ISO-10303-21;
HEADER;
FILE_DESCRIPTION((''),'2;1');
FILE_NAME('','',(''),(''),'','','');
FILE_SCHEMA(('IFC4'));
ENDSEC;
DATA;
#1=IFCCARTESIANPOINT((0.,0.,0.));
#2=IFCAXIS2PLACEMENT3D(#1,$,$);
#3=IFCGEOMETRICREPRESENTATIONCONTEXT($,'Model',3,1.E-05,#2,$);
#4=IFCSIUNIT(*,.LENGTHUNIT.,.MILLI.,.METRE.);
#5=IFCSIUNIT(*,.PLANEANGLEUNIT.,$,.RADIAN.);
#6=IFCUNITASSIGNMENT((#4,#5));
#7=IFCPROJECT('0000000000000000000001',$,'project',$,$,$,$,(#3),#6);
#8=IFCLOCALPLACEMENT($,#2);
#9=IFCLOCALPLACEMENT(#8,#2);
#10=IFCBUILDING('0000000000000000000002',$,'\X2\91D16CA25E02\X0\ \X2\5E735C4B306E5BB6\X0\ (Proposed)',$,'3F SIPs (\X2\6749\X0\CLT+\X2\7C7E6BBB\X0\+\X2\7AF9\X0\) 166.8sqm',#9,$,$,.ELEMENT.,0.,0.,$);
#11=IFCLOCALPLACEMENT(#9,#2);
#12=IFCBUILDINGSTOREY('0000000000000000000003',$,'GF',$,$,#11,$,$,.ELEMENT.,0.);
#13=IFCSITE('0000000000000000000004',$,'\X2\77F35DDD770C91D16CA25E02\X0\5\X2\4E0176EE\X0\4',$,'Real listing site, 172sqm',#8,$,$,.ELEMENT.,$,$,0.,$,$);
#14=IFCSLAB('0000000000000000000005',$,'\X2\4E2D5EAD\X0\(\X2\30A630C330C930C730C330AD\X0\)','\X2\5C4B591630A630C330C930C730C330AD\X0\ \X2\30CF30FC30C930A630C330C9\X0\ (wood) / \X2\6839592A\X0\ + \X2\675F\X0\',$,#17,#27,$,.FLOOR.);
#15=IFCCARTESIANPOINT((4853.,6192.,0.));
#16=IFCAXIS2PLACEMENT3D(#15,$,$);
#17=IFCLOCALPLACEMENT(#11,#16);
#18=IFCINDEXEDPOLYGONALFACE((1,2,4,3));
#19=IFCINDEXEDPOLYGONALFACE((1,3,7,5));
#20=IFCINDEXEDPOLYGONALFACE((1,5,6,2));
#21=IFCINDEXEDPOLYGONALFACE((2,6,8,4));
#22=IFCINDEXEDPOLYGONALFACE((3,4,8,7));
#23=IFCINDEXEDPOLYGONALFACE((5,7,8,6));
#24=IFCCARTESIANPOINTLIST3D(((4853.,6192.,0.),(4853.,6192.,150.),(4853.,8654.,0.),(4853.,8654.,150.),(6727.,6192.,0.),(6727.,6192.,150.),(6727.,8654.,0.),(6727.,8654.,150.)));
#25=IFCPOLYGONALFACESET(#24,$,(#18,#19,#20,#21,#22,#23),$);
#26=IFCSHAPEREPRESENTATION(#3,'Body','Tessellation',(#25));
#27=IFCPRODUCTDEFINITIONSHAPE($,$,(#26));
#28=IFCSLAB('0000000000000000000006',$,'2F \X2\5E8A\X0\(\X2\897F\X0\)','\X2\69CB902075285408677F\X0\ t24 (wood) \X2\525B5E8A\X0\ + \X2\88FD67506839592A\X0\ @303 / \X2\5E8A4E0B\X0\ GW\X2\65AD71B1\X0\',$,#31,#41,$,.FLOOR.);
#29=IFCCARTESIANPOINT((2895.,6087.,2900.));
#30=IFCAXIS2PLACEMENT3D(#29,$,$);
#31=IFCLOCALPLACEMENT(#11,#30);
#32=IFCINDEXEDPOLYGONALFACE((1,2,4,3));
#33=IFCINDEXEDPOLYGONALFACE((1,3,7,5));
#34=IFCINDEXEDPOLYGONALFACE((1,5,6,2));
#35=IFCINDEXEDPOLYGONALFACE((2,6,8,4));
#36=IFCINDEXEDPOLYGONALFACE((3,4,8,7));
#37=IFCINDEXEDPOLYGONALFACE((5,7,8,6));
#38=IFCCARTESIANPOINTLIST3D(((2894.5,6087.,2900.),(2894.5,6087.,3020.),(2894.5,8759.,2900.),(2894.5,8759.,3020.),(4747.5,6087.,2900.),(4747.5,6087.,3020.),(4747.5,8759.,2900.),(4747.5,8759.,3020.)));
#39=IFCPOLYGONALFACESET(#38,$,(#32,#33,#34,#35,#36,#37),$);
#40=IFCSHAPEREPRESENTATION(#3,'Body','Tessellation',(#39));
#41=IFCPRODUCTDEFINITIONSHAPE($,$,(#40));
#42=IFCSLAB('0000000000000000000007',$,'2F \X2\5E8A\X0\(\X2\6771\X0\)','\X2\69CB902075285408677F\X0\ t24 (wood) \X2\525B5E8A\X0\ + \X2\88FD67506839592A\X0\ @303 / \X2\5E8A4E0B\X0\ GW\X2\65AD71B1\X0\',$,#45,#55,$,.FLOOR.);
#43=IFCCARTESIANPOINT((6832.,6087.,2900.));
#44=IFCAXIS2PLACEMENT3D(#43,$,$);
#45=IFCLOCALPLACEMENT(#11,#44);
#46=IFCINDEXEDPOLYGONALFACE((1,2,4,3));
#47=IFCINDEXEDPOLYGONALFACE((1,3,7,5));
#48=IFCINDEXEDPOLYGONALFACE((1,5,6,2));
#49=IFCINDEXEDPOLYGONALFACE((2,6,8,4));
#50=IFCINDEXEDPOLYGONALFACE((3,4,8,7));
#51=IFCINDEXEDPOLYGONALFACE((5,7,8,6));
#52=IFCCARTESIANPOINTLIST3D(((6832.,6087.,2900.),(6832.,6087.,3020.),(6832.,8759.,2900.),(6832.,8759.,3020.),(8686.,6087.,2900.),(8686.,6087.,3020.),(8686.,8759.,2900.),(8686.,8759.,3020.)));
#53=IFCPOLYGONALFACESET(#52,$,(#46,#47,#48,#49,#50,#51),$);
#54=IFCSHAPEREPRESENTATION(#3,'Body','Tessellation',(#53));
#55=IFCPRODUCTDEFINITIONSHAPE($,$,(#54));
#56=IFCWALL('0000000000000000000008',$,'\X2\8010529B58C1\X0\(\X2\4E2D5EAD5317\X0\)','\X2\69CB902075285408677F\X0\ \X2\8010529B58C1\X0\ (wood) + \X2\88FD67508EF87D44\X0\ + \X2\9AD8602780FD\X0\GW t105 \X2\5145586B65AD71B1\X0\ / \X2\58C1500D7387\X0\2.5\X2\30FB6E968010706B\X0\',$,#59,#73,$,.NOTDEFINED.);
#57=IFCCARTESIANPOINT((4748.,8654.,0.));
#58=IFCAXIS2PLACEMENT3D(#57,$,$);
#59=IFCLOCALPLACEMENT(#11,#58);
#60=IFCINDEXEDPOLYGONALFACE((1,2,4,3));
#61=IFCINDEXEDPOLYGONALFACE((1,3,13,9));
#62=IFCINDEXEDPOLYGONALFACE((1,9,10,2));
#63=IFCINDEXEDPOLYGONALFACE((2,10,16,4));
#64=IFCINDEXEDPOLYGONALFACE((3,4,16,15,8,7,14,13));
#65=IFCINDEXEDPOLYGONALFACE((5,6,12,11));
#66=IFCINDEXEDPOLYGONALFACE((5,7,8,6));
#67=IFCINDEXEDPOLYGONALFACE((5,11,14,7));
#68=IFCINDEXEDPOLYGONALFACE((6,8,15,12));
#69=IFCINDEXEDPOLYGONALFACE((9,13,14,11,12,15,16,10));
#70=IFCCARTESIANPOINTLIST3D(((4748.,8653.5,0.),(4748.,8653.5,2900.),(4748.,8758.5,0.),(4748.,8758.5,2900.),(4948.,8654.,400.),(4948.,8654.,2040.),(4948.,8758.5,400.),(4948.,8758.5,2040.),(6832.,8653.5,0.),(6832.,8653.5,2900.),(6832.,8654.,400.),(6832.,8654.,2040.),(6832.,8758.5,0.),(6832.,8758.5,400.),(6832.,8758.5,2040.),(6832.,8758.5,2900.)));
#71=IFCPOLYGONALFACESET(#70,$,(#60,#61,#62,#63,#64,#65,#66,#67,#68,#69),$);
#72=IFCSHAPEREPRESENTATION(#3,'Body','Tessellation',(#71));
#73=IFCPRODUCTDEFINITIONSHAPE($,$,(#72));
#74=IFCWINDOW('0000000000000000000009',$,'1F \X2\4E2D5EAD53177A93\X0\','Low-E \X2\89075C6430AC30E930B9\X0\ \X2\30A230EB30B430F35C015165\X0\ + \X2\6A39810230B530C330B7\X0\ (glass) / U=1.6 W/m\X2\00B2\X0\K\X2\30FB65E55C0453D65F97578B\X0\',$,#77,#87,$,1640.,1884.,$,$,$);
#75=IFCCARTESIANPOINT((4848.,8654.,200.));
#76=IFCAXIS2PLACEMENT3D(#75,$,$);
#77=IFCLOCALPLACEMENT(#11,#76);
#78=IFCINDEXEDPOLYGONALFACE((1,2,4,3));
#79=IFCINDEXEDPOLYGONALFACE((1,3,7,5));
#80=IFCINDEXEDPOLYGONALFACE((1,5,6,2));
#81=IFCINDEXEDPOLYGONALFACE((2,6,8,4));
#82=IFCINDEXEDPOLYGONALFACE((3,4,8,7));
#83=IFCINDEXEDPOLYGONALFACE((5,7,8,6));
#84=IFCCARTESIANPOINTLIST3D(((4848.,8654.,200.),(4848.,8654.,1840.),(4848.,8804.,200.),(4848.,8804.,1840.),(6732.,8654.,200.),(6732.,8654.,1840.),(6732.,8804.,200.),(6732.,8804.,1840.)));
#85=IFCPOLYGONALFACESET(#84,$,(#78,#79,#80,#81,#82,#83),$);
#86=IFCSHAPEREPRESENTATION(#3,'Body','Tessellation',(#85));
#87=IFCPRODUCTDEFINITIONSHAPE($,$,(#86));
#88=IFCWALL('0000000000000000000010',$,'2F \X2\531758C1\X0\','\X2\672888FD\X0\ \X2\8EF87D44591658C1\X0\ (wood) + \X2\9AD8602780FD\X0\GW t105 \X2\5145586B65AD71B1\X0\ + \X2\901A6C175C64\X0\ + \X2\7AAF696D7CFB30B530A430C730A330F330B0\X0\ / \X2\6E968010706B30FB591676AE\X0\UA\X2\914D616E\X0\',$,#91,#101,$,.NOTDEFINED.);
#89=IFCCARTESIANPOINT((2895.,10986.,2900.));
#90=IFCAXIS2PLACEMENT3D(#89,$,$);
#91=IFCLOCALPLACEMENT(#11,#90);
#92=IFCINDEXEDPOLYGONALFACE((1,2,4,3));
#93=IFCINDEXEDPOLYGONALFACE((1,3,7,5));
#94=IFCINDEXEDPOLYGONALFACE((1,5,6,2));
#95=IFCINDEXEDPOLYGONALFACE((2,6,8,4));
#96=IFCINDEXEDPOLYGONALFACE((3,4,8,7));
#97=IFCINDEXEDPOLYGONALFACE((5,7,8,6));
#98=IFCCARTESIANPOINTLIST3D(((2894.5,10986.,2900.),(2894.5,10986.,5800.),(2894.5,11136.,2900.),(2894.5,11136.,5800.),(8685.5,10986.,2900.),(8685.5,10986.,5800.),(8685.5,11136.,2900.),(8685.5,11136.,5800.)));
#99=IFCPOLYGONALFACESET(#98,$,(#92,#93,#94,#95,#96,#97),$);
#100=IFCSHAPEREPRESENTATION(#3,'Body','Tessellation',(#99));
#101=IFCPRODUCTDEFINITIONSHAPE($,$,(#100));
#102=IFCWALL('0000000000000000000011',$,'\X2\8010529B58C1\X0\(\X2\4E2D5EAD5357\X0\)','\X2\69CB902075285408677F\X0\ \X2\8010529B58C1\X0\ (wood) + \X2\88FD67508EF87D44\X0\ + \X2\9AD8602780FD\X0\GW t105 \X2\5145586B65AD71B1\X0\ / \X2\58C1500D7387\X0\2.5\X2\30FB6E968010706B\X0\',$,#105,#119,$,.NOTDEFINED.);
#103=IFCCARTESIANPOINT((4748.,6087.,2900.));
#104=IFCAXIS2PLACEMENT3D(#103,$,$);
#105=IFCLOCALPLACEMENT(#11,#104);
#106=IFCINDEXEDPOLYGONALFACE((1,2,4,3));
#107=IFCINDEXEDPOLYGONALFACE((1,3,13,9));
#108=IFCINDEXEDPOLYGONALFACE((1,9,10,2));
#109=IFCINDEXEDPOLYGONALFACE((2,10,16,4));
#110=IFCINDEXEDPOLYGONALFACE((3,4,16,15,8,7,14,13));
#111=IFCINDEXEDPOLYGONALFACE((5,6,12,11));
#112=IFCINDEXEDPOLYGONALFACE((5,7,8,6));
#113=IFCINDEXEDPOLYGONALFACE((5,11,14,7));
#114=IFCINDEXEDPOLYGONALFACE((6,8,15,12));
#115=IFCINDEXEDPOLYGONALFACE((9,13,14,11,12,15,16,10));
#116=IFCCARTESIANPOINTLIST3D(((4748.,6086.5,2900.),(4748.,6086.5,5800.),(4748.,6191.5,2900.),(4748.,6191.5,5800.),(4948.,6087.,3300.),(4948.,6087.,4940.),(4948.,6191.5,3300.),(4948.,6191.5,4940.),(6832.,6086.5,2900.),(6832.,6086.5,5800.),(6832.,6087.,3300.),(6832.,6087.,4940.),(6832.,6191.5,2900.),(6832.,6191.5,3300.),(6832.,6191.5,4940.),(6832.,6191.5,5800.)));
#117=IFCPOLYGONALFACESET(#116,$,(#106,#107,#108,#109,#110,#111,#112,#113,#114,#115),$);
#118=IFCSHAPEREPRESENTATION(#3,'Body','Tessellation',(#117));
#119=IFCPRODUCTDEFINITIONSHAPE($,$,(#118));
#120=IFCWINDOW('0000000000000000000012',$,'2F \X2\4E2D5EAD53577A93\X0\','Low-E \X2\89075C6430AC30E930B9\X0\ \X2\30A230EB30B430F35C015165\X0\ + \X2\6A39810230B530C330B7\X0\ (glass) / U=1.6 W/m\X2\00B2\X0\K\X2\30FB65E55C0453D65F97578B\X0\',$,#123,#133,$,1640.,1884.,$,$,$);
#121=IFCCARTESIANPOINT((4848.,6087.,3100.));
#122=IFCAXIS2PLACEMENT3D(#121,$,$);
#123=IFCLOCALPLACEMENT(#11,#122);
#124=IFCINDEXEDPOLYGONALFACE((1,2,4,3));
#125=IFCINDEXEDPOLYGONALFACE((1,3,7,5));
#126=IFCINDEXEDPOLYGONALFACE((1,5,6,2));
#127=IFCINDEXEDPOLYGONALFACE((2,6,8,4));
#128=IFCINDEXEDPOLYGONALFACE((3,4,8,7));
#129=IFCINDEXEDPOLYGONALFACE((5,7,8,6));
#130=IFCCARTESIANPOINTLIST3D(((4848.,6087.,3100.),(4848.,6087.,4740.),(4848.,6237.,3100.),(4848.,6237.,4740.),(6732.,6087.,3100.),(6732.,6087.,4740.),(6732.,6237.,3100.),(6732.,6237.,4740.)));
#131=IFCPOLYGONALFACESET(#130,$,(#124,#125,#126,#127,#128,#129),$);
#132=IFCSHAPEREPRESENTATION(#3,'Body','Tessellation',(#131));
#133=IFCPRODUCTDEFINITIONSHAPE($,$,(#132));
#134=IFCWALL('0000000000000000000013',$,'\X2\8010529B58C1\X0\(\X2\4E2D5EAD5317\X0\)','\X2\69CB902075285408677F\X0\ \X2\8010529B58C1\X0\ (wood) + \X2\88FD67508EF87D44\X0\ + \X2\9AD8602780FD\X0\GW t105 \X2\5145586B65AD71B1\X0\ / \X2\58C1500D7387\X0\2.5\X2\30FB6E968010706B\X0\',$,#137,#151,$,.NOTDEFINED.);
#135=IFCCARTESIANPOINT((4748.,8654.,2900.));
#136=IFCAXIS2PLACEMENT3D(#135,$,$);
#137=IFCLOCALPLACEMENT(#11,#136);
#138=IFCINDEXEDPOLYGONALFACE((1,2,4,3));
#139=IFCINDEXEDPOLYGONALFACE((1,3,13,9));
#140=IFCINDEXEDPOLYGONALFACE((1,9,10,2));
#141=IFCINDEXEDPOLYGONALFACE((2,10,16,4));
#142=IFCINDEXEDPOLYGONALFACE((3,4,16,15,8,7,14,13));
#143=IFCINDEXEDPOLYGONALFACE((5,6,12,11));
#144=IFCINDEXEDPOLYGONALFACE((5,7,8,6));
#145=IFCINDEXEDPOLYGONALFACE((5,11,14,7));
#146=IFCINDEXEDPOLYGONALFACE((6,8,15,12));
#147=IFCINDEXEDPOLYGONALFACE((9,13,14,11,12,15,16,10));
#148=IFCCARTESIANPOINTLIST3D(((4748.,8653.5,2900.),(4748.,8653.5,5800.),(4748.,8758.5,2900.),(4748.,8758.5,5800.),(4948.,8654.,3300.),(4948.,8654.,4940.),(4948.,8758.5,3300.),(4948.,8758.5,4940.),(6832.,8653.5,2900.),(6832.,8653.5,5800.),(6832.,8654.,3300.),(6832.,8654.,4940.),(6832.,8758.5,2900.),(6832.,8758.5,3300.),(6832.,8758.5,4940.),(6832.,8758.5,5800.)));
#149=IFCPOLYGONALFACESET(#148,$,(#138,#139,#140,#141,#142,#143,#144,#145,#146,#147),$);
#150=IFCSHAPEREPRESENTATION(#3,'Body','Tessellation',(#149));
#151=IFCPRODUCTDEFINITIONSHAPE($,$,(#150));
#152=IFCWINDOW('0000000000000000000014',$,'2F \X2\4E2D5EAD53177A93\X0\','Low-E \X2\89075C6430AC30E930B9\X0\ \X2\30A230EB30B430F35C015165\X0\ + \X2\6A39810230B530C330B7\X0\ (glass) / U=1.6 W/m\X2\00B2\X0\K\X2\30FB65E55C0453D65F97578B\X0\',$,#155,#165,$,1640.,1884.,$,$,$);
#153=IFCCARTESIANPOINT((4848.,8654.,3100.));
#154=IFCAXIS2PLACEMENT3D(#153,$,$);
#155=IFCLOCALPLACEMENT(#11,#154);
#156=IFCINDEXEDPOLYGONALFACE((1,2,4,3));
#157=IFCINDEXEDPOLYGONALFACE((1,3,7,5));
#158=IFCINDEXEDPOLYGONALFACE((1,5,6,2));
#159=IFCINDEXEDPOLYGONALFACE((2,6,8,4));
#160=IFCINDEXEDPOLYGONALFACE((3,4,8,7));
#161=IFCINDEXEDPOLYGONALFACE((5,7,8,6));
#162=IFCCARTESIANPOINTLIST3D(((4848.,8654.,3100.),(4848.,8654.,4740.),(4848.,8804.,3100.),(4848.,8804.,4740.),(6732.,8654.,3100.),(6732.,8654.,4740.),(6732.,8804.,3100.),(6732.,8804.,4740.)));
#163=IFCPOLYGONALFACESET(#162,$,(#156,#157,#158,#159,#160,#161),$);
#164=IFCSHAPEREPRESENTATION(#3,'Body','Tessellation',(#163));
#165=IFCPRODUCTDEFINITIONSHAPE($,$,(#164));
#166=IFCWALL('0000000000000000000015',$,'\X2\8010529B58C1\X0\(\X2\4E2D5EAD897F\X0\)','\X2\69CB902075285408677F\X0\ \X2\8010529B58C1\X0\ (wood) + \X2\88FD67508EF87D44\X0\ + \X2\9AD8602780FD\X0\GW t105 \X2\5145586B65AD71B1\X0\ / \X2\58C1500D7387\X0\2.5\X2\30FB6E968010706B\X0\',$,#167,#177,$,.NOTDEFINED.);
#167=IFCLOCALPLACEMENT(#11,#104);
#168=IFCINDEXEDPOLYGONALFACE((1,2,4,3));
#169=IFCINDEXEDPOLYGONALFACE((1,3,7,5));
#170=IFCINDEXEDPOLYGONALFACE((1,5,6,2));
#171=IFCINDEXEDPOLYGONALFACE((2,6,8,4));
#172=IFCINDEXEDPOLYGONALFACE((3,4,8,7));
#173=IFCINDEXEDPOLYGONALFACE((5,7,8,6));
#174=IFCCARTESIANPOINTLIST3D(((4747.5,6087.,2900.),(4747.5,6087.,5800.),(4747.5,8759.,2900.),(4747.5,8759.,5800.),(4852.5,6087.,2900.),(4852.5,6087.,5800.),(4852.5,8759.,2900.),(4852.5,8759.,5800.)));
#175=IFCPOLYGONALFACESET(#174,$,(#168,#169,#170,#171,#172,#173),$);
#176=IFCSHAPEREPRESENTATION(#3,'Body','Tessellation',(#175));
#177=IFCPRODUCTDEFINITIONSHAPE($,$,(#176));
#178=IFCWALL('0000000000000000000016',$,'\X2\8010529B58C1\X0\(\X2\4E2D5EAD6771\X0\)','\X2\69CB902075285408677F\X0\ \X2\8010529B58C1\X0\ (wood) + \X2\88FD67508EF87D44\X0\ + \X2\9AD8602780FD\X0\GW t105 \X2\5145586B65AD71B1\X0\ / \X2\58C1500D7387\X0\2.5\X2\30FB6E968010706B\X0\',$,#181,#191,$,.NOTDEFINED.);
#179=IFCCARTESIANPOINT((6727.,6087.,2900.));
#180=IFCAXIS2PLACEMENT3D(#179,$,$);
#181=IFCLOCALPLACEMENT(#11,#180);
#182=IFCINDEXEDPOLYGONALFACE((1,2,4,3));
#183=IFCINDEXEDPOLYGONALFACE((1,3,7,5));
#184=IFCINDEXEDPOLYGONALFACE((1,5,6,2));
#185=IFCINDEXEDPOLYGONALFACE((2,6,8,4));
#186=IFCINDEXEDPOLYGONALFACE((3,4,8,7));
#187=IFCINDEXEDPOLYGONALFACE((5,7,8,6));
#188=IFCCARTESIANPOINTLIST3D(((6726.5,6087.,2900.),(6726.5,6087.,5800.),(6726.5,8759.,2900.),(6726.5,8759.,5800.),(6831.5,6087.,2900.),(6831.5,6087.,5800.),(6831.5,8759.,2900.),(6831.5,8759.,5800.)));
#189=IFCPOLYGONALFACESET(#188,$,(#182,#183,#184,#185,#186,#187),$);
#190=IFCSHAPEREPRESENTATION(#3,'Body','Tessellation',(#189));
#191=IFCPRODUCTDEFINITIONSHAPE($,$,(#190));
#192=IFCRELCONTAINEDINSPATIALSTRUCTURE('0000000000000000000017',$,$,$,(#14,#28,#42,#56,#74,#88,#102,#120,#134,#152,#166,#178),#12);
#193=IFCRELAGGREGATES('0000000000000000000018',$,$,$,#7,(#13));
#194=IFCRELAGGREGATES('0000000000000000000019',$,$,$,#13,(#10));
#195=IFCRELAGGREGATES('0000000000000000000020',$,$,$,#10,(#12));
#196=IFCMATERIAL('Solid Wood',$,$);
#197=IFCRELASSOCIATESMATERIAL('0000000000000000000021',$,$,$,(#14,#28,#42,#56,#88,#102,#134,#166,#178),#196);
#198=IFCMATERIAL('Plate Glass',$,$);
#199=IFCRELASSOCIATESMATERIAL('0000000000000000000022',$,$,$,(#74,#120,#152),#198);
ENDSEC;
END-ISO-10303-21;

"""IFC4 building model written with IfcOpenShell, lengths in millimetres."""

from ifc_helpers import new_model, si_unit, frame, frame_2d, origin, place, context, project, spatial, rectangle, extrude, material, element, fill, save


model = new_model("IFC4")

# Units and contexts
model_context = context("Model", 3, precision=1e-05, world=origin())
ifc_project = project(units=[si_unit("LENGTHUNIT", "METRE", prefix="MILLI"), si_unit("PLANEANGLEUNIT", "RADIAN")], contexts=[model_context])

# Site, building, storey
site_placement = place(None, origin())
site = spatial("IfcSite", under=ifc_project, at=site_placement, Name="石川県金沢市5丁目4", ObjectType="Real listing site, 172sqm", CompositionType="ELEMENT", RefElevation=0.0)
building_placement = place(site_placement, origin())
building = spatial("IfcBuilding", under=site, at=building_placement, Name="金沢市 平屋の家 (Proposed)", ObjectType="3F SIPs (杉CLT+籾殻+竹) 166.8sqm", CompositionType="ELEMENT", ElevationOfRefHeight=0.0, ElevationOfTerrain=0.0)
storey_placement = place(building_placement, origin())
storey = spatial("IfcBuildingStorey", under=building, at=storey_placement, Name="GF", CompositionType="ELEMENT", Elevation=0.0)

# Slabs
ifc_material_1 = material(Name="Solid Wood")
slab_1_placement = place(storey_placement, frame((4853.0, 6192.0, 0.0)))
element("IfcSlab", 1, at=slab_1_placement, inside=storey, material=ifc_material_1, Name="中庭(ウッドデッキ)", Description="屋外ウッドデッキ ハードウッド (wood) / 根太 + 束", PredefinedType="FLOOR", context=model_context, shape_type="SweptSolid", body=[
    extrude(rectangle(XDim=1874.0, YDim=2462.0, at=frame_2d((937.0, 1231.0))), frame((4853.0, 6192.0, 0.0)), (0.0, 0.0, 1.0), 150.0),
])
slab_2_placement = place(storey_placement, frame((2895.0, 6087.0, 2900.0)))
element("IfcSlab", 2, at=slab_2_placement, inside=storey, material=ifc_material_1, Name="2F 床(西)", Description="構造用合板 t24 (wood) 剛床 + 製材根太 @303 / 床下 GW断熱", PredefinedType="FLOOR", context=model_context, shape_type="SweptSolid", body=[
    extrude(rectangle(XDim=1853.0, YDim=2672.0, at=frame_2d((926.0, 1336.0))), frame((2895.0, 6087.0, 2900.0)), (0.0, 0.0, 1.0), 120.0),
])
slab_3_placement = place(storey_placement, frame((6832.0, 6087.0, 2900.0)))
element("IfcSlab", 3, at=slab_3_placement, inside=storey, material=ifc_material_1, Name="2F 床(東)", Description="構造用合板 t24 (wood) 剛床 + 製材根太 @303 / 床下 GW断熱", PredefinedType="FLOOR", context=model_context, shape_type="SweptSolid", body=[
    extrude(rectangle(XDim=1854.0, YDim=2672.0, at=frame_2d((927.0, 1336.0))), frame((6832.0, 6087.0, 2900.0)), (0.0, 0.0, 1.0), 120.0),
])

# Wall, opening, window
wall_1_placement = place(storey_placement, frame((4748.0, 8654.0, 0.0)))
wall_1 = element("IfcWall", 4, at=wall_1_placement, inside=storey, material=ifc_material_1, Name="耐力壁(中庭北)", Description="構造用合板 耐力壁 (wood) + 製材軸組 + 高性能GW t105 充填断熱 / 壁倍率2.5・準耐火", PredefinedType="NOTDEFINED", context=model_context, shape_type="SweptSolid", body=[
    extrude(rectangle(XDim=2084.0, YDim=105.0, at=frame_2d((1042.0, 52.0))), frame((4748.0, 8654.0, 0.0)), (0.0, 0.0, 1.0), 2900.0),
])
opening_1_placement = place(storey_placement, frame((4848.0, 8654.0, 200.0)))
opening_1 = element("IfcOpeningElement", 5, at=opening_1_placement, cuts=wall_1, PredefinedType="NOTDEFINED", context=model_context, shape_type="SweptSolid", body=[
    extrude(rectangle(XDim=1884.0, YDim=150.0, at=frame_2d((942.0, 75.0))), frame((4848.0, 8654.0, 200.0)), (0.0, 0.0, 1.0), 1640.0),
])
ifc_material_2 = material(Name="Plate Glass")
window_1_placement = place(storey_placement, frame((4848.0, 8654.0, 200.0)))
window_1 = element("IfcWindow", 6, at=window_1_placement, inside=storey, material=ifc_material_2, Name="1F 中庭北窓", Description="Low-E 複層ガラス アルゴン封入 + 樹脂サッシ (glass) / U=1.6 W/m²K・日射取得型", OverallHeight=1640.0, OverallWidth=1884.0, context=model_context, shape_type="SweptSolid", body=[
    extrude(rectangle(XDim=1884.0, YDim=150.0, at=frame_2d((942.0, 75.0))), frame((4848.0, 8654.0, 200.0)), (0.0, 0.0, 1.0), 1640.0),
])
fill(opening_1, window_1)

# Wall
wall_2_placement = place(storey_placement, frame((2895.0, 10986.0, 2900.0)))
element("IfcWall", 7, at=wall_2_placement, inside=storey, material=ifc_material_1, Name="2F 北壁", Description="木製 軸組外壁 (wood) + 高性能GW t105 充填断熱 + 通気層 + 窯業系サイディング / 準耐火・外皮UA配慮", PredefinedType="NOTDEFINED", context=model_context, shape_type="SweptSolid", body=[
    extrude(rectangle(XDim=5791.0, YDim=150.0, at=frame_2d((2895.0, 75.0))), frame((2895.0, 10986.0, 2900.0)), (0.0, 0.0, 1.0), 2900.0),
])

# Walls, openings, windows
wall_3_placement = place(storey_placement, frame((4748.0, 6087.0, 2900.0)))
wall_3 = element("IfcWall", 8, at=wall_3_placement, inside=storey, material=ifc_material_1, Name="耐力壁(中庭南)", Description="構造用合板 耐力壁 (wood) + 製材軸組 + 高性能GW t105 充填断熱 / 壁倍率2.5・準耐火", PredefinedType="NOTDEFINED", context=model_context, shape_type="SweptSolid", body=[
    extrude(rectangle(XDim=2084.0, YDim=105.0, at=frame_2d((1042.0, 52.0))), frame((4748.0, 6087.0, 2900.0)), (0.0, 0.0, 1.0), 2900.0),
])
opening_2_placement = place(storey_placement, frame((4848.0, 6087.0, 3100.0)))
opening_2 = element("IfcOpeningElement", 9, at=opening_2_placement, cuts=wall_3, PredefinedType="NOTDEFINED", context=model_context, shape_type="SweptSolid", body=[
    extrude(rectangle(XDim=1884.0, YDim=150.0, at=frame_2d((942.0, 75.0))), frame((4848.0, 6087.0, 3100.0)), (0.0, 0.0, 1.0), 1640.0),
])
window_2_placement = place(storey_placement, frame((4848.0, 6087.0, 3100.0)))
window_2 = element("IfcWindow", 10, at=window_2_placement, inside=storey, material=ifc_material_2, Name="2F 中庭南窓", Description="Low-E 複層ガラス アルゴン封入 + 樹脂サッシ (glass) / U=1.6 W/m²K・日射取得型", OverallHeight=1640.0, OverallWidth=1884.0, context=model_context, shape_type="SweptSolid", body=[
    extrude(rectangle(XDim=1884.0, YDim=150.0, at=frame_2d((942.0, 75.0))), frame((4848.0, 6087.0, 3100.0)), (0.0, 0.0, 1.0), 1640.0),
])
fill(opening_2, window_2)
wall_4_placement = place(storey_placement, frame((4748.0, 8654.0, 2900.0)))
wall_4 = element("IfcWall", 11, at=wall_4_placement, inside=storey, material=ifc_material_1, Name="耐力壁(中庭北)", Description="構造用合板 耐力壁 (wood) + 製材軸組 + 高性能GW t105 充填断熱 / 壁倍率2.5・準耐火", PredefinedType="NOTDEFINED", context=model_context, shape_type="SweptSolid", body=[
    extrude(rectangle(XDim=2084.0, YDim=105.0, at=frame_2d((1042.0, 52.0))), frame((4748.0, 8654.0, 2900.0)), (0.0, 0.0, 1.0), 2900.0),
])
opening_3_placement = place(storey_placement, frame((4848.0, 8654.0, 3100.0)))
opening_3 = element("IfcOpeningElement", 12, at=opening_3_placement, cuts=wall_4, PredefinedType="NOTDEFINED", context=model_context, shape_type="SweptSolid", body=[
    extrude(rectangle(XDim=1884.0, YDim=150.0, at=frame_2d((942.0, 75.0))), frame((4848.0, 8654.0, 3100.0)), (0.0, 0.0, 1.0), 1640.0),
])
window_3_placement = place(storey_placement, frame((4848.0, 8654.0, 3100.0)))
window_3 = element("IfcWindow", 13, at=window_3_placement, inside=storey, material=ifc_material_2, Name="2F 中庭北窓", Description="Low-E 複層ガラス アルゴン封入 + 樹脂サッシ (glass) / U=1.6 W/m²K・日射取得型", OverallHeight=1640.0, OverallWidth=1884.0, context=model_context, shape_type="SweptSolid", body=[
    extrude(rectangle(XDim=1884.0, YDim=150.0, at=frame_2d((942.0, 75.0))), frame((4848.0, 8654.0, 3100.0)), (0.0, 0.0, 1.0), 1640.0),
])
fill(opening_3, window_3)

# Walls
wall_5_placement = place(storey_placement, frame((4748.0, 6087.0, 2900.0)))
element("IfcWall", 14, at=wall_5_placement, inside=storey, material=ifc_material_1, Name="耐力壁(中庭西)", Description="構造用合板 耐力壁 (wood) + 製材軸組 + 高性能GW t105 充填断熱 / 壁倍率2.5・準耐火", PredefinedType="NOTDEFINED", context=model_context, shape_type="SweptSolid", body=[
    extrude(rectangle(XDim=105.0, YDim=2672.0, at=frame_2d((52.0, 1336.0))), frame((4748.0, 6087.0, 2900.0)), (0.0, 0.0, 1.0), 2900.0),
])
wall_6_placement = place(storey_placement, frame((6727.0, 6087.0, 2900.0)))
element("IfcWall", 15, at=wall_6_placement, inside=storey, material=ifc_material_1, Name="耐力壁(中庭東)", Description="構造用合板 耐力壁 (wood) + 製材軸組 + 高性能GW t105 充填断熱 / 壁倍率2.5・準耐火", PredefinedType="NOTDEFINED", context=model_context, shape_type="SweptSolid", body=[
    extrude(rectangle(XDim=105.0, YDim=2672.0, at=frame_2d((52.0, 1336.0))), frame((6727.0, 6087.0, 2900.0)), (0.0, 0.0, 1.0), 2900.0),
])

save(model, "model.ifc")
